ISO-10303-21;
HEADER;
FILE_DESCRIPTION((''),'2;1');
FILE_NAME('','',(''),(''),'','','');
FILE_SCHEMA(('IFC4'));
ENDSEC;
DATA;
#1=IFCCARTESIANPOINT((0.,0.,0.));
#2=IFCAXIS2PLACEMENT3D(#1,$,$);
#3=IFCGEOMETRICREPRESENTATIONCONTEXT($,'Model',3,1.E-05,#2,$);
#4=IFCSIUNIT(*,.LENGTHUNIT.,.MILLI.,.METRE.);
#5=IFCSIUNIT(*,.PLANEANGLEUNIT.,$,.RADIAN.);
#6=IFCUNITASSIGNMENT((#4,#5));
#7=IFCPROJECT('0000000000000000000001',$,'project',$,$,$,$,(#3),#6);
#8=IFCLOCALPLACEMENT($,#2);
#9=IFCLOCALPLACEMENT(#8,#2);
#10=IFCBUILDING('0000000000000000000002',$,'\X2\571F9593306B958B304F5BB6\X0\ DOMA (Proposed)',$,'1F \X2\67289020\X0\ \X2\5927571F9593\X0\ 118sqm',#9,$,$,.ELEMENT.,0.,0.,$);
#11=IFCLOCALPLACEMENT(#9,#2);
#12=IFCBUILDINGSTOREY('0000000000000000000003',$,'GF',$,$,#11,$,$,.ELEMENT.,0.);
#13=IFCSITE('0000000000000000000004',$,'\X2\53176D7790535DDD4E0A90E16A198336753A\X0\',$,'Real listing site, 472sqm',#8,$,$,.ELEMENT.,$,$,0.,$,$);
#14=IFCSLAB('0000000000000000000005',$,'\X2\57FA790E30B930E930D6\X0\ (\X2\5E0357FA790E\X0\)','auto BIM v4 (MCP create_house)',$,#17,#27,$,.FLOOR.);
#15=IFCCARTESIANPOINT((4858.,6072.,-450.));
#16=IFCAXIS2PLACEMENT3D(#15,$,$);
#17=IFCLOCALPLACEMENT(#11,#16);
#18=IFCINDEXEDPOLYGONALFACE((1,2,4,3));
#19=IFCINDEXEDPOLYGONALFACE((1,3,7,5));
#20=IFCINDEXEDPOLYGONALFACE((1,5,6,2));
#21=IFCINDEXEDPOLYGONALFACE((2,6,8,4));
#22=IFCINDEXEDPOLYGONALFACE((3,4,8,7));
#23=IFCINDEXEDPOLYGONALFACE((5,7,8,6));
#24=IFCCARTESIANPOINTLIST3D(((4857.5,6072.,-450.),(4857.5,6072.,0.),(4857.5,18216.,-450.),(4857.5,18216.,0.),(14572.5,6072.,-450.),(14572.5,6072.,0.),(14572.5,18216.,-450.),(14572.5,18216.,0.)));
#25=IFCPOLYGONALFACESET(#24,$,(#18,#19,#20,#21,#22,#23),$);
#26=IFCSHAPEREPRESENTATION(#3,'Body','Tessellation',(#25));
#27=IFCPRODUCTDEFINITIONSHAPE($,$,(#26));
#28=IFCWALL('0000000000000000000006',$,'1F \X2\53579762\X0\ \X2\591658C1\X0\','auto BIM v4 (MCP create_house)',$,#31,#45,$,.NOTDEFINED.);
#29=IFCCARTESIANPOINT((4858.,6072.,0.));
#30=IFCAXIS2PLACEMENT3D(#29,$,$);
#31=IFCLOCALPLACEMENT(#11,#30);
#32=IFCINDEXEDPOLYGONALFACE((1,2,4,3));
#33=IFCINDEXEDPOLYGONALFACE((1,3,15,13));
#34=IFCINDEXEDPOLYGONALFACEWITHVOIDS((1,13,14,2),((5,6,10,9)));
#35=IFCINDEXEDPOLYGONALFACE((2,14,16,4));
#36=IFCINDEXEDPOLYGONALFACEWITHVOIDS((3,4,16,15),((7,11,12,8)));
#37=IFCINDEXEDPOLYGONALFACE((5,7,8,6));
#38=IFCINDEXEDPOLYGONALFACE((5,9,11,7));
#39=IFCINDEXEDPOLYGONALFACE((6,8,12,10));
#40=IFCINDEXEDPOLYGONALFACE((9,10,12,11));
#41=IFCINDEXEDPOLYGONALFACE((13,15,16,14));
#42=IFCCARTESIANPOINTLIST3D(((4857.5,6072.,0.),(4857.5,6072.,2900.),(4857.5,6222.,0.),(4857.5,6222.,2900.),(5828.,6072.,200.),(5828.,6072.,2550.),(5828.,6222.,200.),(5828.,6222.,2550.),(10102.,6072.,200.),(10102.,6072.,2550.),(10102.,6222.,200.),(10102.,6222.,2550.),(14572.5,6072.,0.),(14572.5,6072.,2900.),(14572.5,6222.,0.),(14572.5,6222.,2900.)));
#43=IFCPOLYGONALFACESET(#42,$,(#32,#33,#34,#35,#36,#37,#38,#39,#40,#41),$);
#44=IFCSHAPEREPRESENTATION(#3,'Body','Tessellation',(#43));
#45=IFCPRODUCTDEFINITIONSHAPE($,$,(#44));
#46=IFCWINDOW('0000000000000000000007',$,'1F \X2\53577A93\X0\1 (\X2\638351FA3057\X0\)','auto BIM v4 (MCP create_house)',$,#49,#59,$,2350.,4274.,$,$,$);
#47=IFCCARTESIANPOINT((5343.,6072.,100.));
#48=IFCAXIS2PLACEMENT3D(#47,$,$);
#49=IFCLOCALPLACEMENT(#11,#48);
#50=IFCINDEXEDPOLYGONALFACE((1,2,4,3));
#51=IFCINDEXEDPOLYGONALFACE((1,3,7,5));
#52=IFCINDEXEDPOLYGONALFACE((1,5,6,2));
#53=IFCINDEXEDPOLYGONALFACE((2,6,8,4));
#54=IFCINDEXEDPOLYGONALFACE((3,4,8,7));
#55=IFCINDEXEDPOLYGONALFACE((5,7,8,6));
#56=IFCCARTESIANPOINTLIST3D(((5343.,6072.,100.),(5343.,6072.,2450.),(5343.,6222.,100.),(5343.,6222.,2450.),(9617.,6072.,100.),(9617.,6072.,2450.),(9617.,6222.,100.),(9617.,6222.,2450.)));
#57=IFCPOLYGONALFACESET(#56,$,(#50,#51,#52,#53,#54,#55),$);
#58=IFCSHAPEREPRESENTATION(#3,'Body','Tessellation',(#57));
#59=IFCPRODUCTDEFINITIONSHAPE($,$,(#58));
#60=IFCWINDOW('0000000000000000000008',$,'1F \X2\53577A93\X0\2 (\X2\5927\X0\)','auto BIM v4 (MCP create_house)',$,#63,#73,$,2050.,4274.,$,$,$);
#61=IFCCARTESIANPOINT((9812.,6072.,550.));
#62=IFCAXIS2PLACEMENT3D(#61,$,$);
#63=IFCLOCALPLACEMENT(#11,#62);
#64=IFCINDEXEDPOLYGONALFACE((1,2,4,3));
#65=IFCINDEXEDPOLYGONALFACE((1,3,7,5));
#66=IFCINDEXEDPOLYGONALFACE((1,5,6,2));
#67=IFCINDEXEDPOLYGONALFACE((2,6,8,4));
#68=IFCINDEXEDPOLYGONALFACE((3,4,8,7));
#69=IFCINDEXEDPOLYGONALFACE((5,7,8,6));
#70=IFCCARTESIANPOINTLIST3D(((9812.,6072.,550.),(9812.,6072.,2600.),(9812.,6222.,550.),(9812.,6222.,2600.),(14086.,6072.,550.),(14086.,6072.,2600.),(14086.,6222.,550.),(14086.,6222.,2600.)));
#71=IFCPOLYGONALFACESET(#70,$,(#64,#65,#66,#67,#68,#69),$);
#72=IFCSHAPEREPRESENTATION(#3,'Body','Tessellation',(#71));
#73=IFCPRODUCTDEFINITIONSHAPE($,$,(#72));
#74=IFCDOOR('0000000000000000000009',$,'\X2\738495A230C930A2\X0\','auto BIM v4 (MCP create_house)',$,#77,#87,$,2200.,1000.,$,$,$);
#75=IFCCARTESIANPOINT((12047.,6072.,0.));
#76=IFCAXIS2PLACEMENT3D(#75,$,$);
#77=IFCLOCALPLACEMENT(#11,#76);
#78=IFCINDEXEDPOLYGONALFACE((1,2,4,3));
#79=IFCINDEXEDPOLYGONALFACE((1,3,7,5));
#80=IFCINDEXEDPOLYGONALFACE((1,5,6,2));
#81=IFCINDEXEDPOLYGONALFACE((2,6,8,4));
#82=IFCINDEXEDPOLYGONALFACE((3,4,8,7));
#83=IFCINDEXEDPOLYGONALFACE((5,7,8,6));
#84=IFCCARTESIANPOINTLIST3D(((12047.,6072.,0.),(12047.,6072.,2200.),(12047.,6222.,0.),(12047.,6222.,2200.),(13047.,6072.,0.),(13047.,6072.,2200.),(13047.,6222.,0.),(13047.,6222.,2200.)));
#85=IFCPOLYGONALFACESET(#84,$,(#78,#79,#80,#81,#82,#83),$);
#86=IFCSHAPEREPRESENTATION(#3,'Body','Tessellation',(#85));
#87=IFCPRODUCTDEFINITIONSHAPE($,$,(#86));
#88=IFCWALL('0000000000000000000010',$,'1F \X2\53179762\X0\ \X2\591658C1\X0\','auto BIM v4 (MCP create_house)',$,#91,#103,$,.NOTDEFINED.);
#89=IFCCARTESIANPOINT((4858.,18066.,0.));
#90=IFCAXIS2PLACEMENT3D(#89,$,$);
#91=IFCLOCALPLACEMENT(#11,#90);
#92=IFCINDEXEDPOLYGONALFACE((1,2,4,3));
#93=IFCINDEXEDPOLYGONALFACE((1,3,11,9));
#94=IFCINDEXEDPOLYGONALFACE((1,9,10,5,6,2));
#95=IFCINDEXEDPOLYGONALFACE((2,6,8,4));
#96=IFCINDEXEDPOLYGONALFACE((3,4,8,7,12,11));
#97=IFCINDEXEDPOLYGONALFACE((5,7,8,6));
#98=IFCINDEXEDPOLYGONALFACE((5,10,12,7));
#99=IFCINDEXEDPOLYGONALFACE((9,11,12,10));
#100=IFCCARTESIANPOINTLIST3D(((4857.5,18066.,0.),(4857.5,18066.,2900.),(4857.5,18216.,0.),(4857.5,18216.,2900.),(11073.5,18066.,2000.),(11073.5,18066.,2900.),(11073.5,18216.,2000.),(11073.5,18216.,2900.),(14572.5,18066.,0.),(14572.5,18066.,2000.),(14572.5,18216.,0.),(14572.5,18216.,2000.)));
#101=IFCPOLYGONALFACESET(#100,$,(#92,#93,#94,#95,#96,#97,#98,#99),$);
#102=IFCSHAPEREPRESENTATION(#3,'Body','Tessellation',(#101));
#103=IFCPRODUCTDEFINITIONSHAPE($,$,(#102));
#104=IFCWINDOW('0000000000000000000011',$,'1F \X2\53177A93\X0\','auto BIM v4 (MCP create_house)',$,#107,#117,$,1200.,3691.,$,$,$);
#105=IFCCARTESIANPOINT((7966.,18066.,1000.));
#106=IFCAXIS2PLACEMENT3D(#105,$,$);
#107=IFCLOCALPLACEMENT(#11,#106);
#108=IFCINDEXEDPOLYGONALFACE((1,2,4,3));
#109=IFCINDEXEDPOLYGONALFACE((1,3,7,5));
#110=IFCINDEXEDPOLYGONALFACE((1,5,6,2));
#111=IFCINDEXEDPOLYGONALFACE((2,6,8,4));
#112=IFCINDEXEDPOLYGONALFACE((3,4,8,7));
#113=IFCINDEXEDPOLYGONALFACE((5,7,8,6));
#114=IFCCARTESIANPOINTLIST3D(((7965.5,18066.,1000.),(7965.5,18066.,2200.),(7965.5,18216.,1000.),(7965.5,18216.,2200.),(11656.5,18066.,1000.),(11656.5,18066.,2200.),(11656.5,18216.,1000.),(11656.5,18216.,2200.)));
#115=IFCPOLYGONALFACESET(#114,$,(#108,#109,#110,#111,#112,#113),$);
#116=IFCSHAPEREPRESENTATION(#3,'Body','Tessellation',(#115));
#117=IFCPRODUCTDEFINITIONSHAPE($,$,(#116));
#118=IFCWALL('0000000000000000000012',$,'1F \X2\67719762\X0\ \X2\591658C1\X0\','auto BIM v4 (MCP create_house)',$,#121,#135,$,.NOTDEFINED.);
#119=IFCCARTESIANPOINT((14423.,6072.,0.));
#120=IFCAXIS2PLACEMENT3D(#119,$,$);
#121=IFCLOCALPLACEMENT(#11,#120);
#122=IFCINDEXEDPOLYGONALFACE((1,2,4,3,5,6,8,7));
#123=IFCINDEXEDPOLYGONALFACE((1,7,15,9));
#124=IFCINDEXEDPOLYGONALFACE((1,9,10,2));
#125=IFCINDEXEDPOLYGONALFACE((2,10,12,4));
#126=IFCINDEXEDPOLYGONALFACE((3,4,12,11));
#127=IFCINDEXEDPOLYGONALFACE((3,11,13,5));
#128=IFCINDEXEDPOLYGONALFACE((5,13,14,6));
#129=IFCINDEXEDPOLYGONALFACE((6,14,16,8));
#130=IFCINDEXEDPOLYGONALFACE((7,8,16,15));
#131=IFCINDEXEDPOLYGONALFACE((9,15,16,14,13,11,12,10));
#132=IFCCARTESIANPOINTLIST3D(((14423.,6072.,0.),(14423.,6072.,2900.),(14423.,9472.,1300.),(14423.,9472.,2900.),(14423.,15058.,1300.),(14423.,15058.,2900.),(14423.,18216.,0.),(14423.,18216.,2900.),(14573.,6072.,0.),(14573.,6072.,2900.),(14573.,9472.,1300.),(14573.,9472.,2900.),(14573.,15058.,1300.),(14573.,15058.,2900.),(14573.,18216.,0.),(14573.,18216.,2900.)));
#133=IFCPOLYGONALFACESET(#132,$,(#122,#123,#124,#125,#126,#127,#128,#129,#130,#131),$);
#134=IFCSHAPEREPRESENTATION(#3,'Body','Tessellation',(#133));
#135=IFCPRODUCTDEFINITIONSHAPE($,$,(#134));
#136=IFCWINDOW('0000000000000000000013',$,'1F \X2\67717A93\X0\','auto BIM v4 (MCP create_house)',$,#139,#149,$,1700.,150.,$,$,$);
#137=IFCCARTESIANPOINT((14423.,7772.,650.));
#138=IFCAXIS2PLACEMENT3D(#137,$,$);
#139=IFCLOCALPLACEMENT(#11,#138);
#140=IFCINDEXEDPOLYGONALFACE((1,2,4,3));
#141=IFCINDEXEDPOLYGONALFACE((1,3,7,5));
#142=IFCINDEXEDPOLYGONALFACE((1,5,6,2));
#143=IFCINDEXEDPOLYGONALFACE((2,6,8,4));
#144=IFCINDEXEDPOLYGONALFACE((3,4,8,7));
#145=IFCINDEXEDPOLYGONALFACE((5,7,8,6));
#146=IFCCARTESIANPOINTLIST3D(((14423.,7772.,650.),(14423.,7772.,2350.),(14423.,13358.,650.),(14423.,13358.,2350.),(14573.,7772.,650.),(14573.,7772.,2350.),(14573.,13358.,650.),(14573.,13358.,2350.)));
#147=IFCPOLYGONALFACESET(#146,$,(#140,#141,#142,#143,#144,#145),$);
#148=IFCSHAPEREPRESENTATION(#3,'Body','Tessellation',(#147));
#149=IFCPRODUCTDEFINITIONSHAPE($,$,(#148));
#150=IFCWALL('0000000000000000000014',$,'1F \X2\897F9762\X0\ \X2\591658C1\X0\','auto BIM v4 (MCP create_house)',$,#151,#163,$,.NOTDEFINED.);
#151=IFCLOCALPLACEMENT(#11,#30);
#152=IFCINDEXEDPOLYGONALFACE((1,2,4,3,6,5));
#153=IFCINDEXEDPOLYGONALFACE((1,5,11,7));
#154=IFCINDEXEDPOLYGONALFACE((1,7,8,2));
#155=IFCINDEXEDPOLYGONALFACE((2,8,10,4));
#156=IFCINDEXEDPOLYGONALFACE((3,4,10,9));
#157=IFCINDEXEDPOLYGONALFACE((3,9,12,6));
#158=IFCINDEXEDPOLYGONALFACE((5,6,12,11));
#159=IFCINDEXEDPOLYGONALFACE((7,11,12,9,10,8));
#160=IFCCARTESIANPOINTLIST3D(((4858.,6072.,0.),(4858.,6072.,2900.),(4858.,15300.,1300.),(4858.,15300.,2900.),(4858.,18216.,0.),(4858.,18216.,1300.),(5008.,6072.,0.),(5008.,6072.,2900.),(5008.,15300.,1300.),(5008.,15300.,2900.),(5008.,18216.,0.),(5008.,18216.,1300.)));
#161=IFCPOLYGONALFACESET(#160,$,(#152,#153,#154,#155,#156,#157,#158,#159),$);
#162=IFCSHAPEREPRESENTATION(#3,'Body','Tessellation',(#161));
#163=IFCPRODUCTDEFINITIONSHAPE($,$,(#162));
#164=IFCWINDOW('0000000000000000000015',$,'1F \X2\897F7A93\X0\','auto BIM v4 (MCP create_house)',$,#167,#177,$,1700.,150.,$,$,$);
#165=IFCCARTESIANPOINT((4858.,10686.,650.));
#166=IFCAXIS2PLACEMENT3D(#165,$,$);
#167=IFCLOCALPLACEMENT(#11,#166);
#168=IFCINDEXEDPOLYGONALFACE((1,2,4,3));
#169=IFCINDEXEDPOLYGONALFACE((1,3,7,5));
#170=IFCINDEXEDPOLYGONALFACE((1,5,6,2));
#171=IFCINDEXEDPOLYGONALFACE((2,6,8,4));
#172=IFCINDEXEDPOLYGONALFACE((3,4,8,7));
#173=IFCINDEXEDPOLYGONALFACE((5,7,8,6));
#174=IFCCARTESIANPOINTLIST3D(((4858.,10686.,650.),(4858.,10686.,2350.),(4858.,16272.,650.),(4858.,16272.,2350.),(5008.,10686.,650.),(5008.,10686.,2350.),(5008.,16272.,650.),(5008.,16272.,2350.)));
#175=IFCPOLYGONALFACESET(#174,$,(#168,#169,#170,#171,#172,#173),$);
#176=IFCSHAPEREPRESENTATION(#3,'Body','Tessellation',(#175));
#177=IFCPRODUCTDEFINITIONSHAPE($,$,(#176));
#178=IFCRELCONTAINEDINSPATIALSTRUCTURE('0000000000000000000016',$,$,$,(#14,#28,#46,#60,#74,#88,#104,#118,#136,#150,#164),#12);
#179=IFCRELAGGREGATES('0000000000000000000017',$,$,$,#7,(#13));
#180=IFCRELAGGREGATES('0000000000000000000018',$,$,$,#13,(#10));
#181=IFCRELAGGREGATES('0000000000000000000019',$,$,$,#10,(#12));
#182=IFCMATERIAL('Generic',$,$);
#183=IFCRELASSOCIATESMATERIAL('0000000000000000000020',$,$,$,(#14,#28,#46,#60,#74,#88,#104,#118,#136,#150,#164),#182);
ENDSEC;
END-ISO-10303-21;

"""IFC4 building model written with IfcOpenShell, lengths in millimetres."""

from ifc_helpers import new_model, si_unit, frame, frame_2d, origin, place, context, project, spatial, rectangle, extrude, material, element, fill, save


model = new_model("IFC4")

# Units and contexts
model_context = context("Model", 3, precision=1e-05, world=origin())
ifc_project = project(units=[si_unit("LENGTHUNIT", "METRE", prefix="MILLI"), si_unit("PLANEANGLEUNIT", "RADIAN")], contexts=[model_context])

# Site, building, storey
site_placement = place(None, origin())
site = spatial("IfcSite", under=ifc_project, at=site_placement, Name="北海道川上郡標茶町", ObjectType="Real listing site, 472sqm", CompositionType="ELEMENT", RefElevation=0.0)
building_placement = place(site_placement, origin())
building = spatial("IfcBuilding", under=site, at=building_placement, Name="土間に開く家 DOMA (Proposed)", ObjectType="1F 木造 大土間 118sqm", CompositionType="ELEMENT", ElevationOfRefHeight=0.0, ElevationOfTerrain=0.0)
storey_placement = place(building_placement, origin())
storey = spatial("IfcBuildingStorey", under=building, at=storey_placement, Name="GF", CompositionType="ELEMENT", Elevation=0.0)

# Slab
ifc_material = material(Name="Generic")
slab_1_placement = place(storey_placement, frame((4858.0, 6072.0, -450.0)))
element("IfcSlab", 1, at=slab_1_placement, inside=storey, material=ifc_material, Name="基礎スラブ (布基礎)", Description="auto BIM v4 (MCP create_house)", PredefinedType="FLOOR", context=model_context, shape_type="SweptSolid", body=[
    extrude(rectangle(XDim=9715.0, YDim=12144.0, at=frame_2d((4857.0, 6072.0))), frame((4858.0, 6072.0, -450.0)), (0.0, 0.0, 1.0), 450.0),
])

# Wall, openings, windows, door
wall_1_placement = place(storey_placement, frame((4858.0, 6072.0, 0.0)))
wall_1 = element("IfcWall", 2, at=wall_1_placement, inside=storey, material=ifc_material, Name="1F 南面 外壁", Description="auto BIM v4 (MCP create_house)", PredefinedType="NOTDEFINED", context=model_context, shape_type="SweptSolid", body=[
    extrude(rectangle(XDim=9715.0, YDim=150.0, at=frame_2d((4857.0, 75.0))), frame((4858.0, 6072.0, 0.0)), (0.0, 0.0, 1.0), 2900.0),
])
opening_1_placement = place(storey_placement, frame((5343.0, 6072.0, 100.0)))
opening_1 = element("IfcOpeningElement", 3, at=opening_1_placement, cuts=wall_1, PredefinedType="NOTDEFINED", context=model_context, shape_type="SweptSolid", body=[
    extrude(rectangle(XDim=4274.0, YDim=150.0, at=frame_2d((2137.0, 75.0))), frame((5343.0, 6072.0, 100.0)), (0.0, 0.0, 1.0), 2350.0),
])
opening_2_placement = place(storey_placement, frame((9812.0, 6072.0, 550.0)))
opening_2 = element("IfcOpeningElement", 4, at=opening_2_placement, cuts=wall_1, PredefinedType="NOTDEFINED", context=model_context, shape_type="SweptSolid", body=[
    extrude(rectangle(XDim=4274.0, YDim=150.0, at=frame_2d((2137.0, 75.0))), frame((9812.0, 6072.0, 550.0)), (0.0, 0.0, 1.0), 2050.0),
])
opening_3_placement = place(storey_placement, frame((12047.0, 6072.0, 0.0)))
opening_3 = element("IfcOpeningElement", 5, at=opening_3_placement, cuts=wall_1, PredefinedType="NOTDEFINED", context=model_context, shape_type="SweptSolid", body=[
    extrude(rectangle(XDim=1000.0, YDim=150.0, at=frame_2d((500.0, 75.0))), frame((12047.0, 6072.0, 0.0)), (0.0, 0.0, 1.0), 2200.0),
])
window_1_placement = place(storey_placement, frame((5343.0, 6072.0, 100.0)))
window_1 = element("IfcWindow", 6, at=window_1_placement, inside=storey, material=ifc_material, Name="1F 南窓1 (掃出し)", Description="auto BIM v4 (MCP create_house)", OverallHeight=2350.0, OverallWidth=4274.0, context=model_context, shape_type="SweptSolid", body=[
    extrude(rectangle(XDim=4274.0, YDim=150.0, at=frame_2d((2137.0, 75.0))), frame((5343.0, 6072.0, 100.0)), (0.0, 0.0, 1.0), 2350.0),
])
fill(opening_1, window_1)
window_2_placement = place(storey_placement, frame((9812.0, 6072.0, 550.0)))
window_2 = element("IfcWindow", 7, at=window_2_placement, inside=storey, material=ifc_material, Name="1F 南窓2 (大)", Description="auto BIM v4 (MCP create_house)", OverallHeight=2050.0, OverallWidth=4274.0, context=model_context, shape_type="SweptSolid", body=[
    extrude(rectangle(XDim=4274.0, YDim=150.0, at=frame_2d((2137.0, 75.0))), frame((9812.0, 6072.0, 550.0)), (0.0, 0.0, 1.0), 2050.0),
])
fill(opening_2, window_2)
door_placement = place(storey_placement, frame((12047.0, 6072.0, 0.0)))
door = element("IfcDoor", 8, at=door_placement, inside=storey, material=ifc_material, Name="玄関ドア", Description="auto BIM v4 (MCP create_house)", OverallHeight=2200.0, OverallWidth=1000.0, context=model_context, shape_type="SweptSolid", body=[
    extrude(rectangle(XDim=1000.0, YDim=150.0, at=frame_2d((500.0, 75.0))), frame((12047.0, 6072.0, 0.0)), (0.0, 0.0, 1.0), 2200.0),
])
fill(opening_3, door)

# Walls, openings, windows
wall_2_placement = place(storey_placement, frame((4858.0, 18066.0, 0.0)))
wall_2 = element("IfcWall", 9, at=wall_2_placement, inside=storey, material=ifc_material, Name="1F 北面 外壁", Description="auto BIM v4 (MCP create_house)", PredefinedType="NOTDEFINED", context=model_context, shape_type="SweptSolid", body=[
    extrude(rectangle(XDim=9715.0, YDim=150.0, at=frame_2d((4857.0, 75.0))), frame((4858.0, 18066.0, 0.0)), (0.0, 0.0, 1.0), 2900.0),
])
opening_4_placement = place(storey_placement, frame((7966.0, 18066.0, 1000.0)))
opening_4 = element("IfcOpeningElement", 10, at=opening_4_placement, cuts=wall_2, PredefinedType="NOTDEFINED", context=model_context, shape_type="SweptSolid", body=[
    extrude(rectangle(XDim=3691.0, YDim=150.0, at=frame_2d((1845.0, 75.0))), frame((7966.0, 18066.0, 1000.0)), (0.0, 0.0, 1.0), 1200.0),
])
window_3_placement = place(storey_placement, frame((7966.0, 18066.0, 1000.0)))
window_3 = element("IfcWindow", 11, at=window_3_placement, inside=storey, material=ifc_material, Name="1F 北窓", Description="auto BIM v4 (MCP create_house)", OverallHeight=1200.0, OverallWidth=3691.0, context=model_context, shape_type="SweptSolid", body=[
    extrude(rectangle(XDim=3691.0, YDim=150.0, at=frame_2d((1845.0, 75.0))), frame((7966.0, 18066.0, 1000.0)), (0.0, 0.0, 1.0), 1200.0),
])
fill(opening_4, window_3)
wall_3_placement = place(storey_placement, frame((14423.0, 6072.0, 0.0)))
wall_3 = element("IfcWall", 12, at=wall_3_placement, inside=storey, material=ifc_material, Name="1F 東面 外壁", Description="auto BIM v4 (MCP create_house)", PredefinedType="NOTDEFINED", context=model_context, shape_type="SweptSolid", body=[
    extrude(rectangle(XDim=150.0, YDim=12144.0, at=frame_2d((75.0, 6072.0))), frame((14423.0, 6072.0, 0.0)), (0.0, 0.0, 1.0), 2900.0),
])
opening_5_placement = place(storey_placement, frame((14423.0, 7772.0, 650.0)))
opening_5 = element("IfcOpeningElement", 13, at=opening_5_placement, cuts=wall_3, PredefinedType="NOTDEFINED", context=model_context, shape_type="SweptSolid", body=[
    extrude(rectangle(XDim=150.0, YDim=5586.0, at=frame_2d((75.0, 2793.0))), frame((14423.0, 7772.0, 650.0)), (0.0, 0.0, 1.0), 1700.0),
])
window_4_placement = place(storey_placement, frame((14423.0, 7772.0, 650.0)))
window_4 = element("IfcWindow", 14, at=window_4_placement, inside=storey, material=ifc_material, Name="1F 東窓", Description="auto BIM v4 (MCP create_house)", OverallHeight=1700.0, OverallWidth=150.0, context=model_context, shape_type="SweptSolid", body=[
    extrude(rectangle(XDim=150.0, YDim=5586.0, at=frame_2d((75.0, 2793.0))), frame((14423.0, 7772.0, 650.0)), (0.0, 0.0, 1.0), 1700.0),
])
fill(opening_5, window_4)
wall_4_placement = place(storey_placement, frame((4858.0, 6072.0, 0.0)))
wall_4 = element("IfcWall", 15, at=wall_4_placement, inside=storey, material=ifc_material, Name="1F 西面 外壁", Description="auto BIM v4 (MCP create_house)", PredefinedType="NOTDEFINED", context=model_context, shape_type="SweptSolid", body=[
    extrude(rectangle(XDim=150.0, YDim=12144.0, at=frame_2d((75.0, 6072.0))), frame((4858.0, 6072.0, 0.0)), (0.0, 0.0, 1.0), 2900.0),
])
opening_6_placement = place(storey_placement, frame((4858.0, 10686.0, 650.0)))
opening_6 = element("IfcOpeningElement", 16, at=opening_6_placement, cuts=wall_4, PredefinedType="NOTDEFINED", context=model_context, shape_type="SweptSolid", body=[
    extrude(rectangle(XDim=150.0, YDim=5586.0, at=frame_2d((75.0, 2793.0))), frame((4858.0, 10686.0, 650.0)), (0.0, 0.0, 1.0), 1700.0),
])
window_5_placement = place(storey_placement, frame((4858.0, 10686.0, 650.0)))
window_5 = element("IfcWindow", 17, at=window_5_placement, inside=storey, material=ifc_material, Name="1F 西窓", Description="auto BIM v4 (MCP create_house)", OverallHeight=1700.0, OverallWidth=150.0, context=model_context, shape_type="SweptSolid", body=[
    extrude(rectangle(XDim=150.0, YDim=5586.0, at=frame_2d((75.0, 2793.0))), frame((4858.0, 10686.0, 650.0)), (0.0, 0.0, 1.0), 1700.0),
])
fill(opening_6, window_5)

save(model, "model.ifc")
